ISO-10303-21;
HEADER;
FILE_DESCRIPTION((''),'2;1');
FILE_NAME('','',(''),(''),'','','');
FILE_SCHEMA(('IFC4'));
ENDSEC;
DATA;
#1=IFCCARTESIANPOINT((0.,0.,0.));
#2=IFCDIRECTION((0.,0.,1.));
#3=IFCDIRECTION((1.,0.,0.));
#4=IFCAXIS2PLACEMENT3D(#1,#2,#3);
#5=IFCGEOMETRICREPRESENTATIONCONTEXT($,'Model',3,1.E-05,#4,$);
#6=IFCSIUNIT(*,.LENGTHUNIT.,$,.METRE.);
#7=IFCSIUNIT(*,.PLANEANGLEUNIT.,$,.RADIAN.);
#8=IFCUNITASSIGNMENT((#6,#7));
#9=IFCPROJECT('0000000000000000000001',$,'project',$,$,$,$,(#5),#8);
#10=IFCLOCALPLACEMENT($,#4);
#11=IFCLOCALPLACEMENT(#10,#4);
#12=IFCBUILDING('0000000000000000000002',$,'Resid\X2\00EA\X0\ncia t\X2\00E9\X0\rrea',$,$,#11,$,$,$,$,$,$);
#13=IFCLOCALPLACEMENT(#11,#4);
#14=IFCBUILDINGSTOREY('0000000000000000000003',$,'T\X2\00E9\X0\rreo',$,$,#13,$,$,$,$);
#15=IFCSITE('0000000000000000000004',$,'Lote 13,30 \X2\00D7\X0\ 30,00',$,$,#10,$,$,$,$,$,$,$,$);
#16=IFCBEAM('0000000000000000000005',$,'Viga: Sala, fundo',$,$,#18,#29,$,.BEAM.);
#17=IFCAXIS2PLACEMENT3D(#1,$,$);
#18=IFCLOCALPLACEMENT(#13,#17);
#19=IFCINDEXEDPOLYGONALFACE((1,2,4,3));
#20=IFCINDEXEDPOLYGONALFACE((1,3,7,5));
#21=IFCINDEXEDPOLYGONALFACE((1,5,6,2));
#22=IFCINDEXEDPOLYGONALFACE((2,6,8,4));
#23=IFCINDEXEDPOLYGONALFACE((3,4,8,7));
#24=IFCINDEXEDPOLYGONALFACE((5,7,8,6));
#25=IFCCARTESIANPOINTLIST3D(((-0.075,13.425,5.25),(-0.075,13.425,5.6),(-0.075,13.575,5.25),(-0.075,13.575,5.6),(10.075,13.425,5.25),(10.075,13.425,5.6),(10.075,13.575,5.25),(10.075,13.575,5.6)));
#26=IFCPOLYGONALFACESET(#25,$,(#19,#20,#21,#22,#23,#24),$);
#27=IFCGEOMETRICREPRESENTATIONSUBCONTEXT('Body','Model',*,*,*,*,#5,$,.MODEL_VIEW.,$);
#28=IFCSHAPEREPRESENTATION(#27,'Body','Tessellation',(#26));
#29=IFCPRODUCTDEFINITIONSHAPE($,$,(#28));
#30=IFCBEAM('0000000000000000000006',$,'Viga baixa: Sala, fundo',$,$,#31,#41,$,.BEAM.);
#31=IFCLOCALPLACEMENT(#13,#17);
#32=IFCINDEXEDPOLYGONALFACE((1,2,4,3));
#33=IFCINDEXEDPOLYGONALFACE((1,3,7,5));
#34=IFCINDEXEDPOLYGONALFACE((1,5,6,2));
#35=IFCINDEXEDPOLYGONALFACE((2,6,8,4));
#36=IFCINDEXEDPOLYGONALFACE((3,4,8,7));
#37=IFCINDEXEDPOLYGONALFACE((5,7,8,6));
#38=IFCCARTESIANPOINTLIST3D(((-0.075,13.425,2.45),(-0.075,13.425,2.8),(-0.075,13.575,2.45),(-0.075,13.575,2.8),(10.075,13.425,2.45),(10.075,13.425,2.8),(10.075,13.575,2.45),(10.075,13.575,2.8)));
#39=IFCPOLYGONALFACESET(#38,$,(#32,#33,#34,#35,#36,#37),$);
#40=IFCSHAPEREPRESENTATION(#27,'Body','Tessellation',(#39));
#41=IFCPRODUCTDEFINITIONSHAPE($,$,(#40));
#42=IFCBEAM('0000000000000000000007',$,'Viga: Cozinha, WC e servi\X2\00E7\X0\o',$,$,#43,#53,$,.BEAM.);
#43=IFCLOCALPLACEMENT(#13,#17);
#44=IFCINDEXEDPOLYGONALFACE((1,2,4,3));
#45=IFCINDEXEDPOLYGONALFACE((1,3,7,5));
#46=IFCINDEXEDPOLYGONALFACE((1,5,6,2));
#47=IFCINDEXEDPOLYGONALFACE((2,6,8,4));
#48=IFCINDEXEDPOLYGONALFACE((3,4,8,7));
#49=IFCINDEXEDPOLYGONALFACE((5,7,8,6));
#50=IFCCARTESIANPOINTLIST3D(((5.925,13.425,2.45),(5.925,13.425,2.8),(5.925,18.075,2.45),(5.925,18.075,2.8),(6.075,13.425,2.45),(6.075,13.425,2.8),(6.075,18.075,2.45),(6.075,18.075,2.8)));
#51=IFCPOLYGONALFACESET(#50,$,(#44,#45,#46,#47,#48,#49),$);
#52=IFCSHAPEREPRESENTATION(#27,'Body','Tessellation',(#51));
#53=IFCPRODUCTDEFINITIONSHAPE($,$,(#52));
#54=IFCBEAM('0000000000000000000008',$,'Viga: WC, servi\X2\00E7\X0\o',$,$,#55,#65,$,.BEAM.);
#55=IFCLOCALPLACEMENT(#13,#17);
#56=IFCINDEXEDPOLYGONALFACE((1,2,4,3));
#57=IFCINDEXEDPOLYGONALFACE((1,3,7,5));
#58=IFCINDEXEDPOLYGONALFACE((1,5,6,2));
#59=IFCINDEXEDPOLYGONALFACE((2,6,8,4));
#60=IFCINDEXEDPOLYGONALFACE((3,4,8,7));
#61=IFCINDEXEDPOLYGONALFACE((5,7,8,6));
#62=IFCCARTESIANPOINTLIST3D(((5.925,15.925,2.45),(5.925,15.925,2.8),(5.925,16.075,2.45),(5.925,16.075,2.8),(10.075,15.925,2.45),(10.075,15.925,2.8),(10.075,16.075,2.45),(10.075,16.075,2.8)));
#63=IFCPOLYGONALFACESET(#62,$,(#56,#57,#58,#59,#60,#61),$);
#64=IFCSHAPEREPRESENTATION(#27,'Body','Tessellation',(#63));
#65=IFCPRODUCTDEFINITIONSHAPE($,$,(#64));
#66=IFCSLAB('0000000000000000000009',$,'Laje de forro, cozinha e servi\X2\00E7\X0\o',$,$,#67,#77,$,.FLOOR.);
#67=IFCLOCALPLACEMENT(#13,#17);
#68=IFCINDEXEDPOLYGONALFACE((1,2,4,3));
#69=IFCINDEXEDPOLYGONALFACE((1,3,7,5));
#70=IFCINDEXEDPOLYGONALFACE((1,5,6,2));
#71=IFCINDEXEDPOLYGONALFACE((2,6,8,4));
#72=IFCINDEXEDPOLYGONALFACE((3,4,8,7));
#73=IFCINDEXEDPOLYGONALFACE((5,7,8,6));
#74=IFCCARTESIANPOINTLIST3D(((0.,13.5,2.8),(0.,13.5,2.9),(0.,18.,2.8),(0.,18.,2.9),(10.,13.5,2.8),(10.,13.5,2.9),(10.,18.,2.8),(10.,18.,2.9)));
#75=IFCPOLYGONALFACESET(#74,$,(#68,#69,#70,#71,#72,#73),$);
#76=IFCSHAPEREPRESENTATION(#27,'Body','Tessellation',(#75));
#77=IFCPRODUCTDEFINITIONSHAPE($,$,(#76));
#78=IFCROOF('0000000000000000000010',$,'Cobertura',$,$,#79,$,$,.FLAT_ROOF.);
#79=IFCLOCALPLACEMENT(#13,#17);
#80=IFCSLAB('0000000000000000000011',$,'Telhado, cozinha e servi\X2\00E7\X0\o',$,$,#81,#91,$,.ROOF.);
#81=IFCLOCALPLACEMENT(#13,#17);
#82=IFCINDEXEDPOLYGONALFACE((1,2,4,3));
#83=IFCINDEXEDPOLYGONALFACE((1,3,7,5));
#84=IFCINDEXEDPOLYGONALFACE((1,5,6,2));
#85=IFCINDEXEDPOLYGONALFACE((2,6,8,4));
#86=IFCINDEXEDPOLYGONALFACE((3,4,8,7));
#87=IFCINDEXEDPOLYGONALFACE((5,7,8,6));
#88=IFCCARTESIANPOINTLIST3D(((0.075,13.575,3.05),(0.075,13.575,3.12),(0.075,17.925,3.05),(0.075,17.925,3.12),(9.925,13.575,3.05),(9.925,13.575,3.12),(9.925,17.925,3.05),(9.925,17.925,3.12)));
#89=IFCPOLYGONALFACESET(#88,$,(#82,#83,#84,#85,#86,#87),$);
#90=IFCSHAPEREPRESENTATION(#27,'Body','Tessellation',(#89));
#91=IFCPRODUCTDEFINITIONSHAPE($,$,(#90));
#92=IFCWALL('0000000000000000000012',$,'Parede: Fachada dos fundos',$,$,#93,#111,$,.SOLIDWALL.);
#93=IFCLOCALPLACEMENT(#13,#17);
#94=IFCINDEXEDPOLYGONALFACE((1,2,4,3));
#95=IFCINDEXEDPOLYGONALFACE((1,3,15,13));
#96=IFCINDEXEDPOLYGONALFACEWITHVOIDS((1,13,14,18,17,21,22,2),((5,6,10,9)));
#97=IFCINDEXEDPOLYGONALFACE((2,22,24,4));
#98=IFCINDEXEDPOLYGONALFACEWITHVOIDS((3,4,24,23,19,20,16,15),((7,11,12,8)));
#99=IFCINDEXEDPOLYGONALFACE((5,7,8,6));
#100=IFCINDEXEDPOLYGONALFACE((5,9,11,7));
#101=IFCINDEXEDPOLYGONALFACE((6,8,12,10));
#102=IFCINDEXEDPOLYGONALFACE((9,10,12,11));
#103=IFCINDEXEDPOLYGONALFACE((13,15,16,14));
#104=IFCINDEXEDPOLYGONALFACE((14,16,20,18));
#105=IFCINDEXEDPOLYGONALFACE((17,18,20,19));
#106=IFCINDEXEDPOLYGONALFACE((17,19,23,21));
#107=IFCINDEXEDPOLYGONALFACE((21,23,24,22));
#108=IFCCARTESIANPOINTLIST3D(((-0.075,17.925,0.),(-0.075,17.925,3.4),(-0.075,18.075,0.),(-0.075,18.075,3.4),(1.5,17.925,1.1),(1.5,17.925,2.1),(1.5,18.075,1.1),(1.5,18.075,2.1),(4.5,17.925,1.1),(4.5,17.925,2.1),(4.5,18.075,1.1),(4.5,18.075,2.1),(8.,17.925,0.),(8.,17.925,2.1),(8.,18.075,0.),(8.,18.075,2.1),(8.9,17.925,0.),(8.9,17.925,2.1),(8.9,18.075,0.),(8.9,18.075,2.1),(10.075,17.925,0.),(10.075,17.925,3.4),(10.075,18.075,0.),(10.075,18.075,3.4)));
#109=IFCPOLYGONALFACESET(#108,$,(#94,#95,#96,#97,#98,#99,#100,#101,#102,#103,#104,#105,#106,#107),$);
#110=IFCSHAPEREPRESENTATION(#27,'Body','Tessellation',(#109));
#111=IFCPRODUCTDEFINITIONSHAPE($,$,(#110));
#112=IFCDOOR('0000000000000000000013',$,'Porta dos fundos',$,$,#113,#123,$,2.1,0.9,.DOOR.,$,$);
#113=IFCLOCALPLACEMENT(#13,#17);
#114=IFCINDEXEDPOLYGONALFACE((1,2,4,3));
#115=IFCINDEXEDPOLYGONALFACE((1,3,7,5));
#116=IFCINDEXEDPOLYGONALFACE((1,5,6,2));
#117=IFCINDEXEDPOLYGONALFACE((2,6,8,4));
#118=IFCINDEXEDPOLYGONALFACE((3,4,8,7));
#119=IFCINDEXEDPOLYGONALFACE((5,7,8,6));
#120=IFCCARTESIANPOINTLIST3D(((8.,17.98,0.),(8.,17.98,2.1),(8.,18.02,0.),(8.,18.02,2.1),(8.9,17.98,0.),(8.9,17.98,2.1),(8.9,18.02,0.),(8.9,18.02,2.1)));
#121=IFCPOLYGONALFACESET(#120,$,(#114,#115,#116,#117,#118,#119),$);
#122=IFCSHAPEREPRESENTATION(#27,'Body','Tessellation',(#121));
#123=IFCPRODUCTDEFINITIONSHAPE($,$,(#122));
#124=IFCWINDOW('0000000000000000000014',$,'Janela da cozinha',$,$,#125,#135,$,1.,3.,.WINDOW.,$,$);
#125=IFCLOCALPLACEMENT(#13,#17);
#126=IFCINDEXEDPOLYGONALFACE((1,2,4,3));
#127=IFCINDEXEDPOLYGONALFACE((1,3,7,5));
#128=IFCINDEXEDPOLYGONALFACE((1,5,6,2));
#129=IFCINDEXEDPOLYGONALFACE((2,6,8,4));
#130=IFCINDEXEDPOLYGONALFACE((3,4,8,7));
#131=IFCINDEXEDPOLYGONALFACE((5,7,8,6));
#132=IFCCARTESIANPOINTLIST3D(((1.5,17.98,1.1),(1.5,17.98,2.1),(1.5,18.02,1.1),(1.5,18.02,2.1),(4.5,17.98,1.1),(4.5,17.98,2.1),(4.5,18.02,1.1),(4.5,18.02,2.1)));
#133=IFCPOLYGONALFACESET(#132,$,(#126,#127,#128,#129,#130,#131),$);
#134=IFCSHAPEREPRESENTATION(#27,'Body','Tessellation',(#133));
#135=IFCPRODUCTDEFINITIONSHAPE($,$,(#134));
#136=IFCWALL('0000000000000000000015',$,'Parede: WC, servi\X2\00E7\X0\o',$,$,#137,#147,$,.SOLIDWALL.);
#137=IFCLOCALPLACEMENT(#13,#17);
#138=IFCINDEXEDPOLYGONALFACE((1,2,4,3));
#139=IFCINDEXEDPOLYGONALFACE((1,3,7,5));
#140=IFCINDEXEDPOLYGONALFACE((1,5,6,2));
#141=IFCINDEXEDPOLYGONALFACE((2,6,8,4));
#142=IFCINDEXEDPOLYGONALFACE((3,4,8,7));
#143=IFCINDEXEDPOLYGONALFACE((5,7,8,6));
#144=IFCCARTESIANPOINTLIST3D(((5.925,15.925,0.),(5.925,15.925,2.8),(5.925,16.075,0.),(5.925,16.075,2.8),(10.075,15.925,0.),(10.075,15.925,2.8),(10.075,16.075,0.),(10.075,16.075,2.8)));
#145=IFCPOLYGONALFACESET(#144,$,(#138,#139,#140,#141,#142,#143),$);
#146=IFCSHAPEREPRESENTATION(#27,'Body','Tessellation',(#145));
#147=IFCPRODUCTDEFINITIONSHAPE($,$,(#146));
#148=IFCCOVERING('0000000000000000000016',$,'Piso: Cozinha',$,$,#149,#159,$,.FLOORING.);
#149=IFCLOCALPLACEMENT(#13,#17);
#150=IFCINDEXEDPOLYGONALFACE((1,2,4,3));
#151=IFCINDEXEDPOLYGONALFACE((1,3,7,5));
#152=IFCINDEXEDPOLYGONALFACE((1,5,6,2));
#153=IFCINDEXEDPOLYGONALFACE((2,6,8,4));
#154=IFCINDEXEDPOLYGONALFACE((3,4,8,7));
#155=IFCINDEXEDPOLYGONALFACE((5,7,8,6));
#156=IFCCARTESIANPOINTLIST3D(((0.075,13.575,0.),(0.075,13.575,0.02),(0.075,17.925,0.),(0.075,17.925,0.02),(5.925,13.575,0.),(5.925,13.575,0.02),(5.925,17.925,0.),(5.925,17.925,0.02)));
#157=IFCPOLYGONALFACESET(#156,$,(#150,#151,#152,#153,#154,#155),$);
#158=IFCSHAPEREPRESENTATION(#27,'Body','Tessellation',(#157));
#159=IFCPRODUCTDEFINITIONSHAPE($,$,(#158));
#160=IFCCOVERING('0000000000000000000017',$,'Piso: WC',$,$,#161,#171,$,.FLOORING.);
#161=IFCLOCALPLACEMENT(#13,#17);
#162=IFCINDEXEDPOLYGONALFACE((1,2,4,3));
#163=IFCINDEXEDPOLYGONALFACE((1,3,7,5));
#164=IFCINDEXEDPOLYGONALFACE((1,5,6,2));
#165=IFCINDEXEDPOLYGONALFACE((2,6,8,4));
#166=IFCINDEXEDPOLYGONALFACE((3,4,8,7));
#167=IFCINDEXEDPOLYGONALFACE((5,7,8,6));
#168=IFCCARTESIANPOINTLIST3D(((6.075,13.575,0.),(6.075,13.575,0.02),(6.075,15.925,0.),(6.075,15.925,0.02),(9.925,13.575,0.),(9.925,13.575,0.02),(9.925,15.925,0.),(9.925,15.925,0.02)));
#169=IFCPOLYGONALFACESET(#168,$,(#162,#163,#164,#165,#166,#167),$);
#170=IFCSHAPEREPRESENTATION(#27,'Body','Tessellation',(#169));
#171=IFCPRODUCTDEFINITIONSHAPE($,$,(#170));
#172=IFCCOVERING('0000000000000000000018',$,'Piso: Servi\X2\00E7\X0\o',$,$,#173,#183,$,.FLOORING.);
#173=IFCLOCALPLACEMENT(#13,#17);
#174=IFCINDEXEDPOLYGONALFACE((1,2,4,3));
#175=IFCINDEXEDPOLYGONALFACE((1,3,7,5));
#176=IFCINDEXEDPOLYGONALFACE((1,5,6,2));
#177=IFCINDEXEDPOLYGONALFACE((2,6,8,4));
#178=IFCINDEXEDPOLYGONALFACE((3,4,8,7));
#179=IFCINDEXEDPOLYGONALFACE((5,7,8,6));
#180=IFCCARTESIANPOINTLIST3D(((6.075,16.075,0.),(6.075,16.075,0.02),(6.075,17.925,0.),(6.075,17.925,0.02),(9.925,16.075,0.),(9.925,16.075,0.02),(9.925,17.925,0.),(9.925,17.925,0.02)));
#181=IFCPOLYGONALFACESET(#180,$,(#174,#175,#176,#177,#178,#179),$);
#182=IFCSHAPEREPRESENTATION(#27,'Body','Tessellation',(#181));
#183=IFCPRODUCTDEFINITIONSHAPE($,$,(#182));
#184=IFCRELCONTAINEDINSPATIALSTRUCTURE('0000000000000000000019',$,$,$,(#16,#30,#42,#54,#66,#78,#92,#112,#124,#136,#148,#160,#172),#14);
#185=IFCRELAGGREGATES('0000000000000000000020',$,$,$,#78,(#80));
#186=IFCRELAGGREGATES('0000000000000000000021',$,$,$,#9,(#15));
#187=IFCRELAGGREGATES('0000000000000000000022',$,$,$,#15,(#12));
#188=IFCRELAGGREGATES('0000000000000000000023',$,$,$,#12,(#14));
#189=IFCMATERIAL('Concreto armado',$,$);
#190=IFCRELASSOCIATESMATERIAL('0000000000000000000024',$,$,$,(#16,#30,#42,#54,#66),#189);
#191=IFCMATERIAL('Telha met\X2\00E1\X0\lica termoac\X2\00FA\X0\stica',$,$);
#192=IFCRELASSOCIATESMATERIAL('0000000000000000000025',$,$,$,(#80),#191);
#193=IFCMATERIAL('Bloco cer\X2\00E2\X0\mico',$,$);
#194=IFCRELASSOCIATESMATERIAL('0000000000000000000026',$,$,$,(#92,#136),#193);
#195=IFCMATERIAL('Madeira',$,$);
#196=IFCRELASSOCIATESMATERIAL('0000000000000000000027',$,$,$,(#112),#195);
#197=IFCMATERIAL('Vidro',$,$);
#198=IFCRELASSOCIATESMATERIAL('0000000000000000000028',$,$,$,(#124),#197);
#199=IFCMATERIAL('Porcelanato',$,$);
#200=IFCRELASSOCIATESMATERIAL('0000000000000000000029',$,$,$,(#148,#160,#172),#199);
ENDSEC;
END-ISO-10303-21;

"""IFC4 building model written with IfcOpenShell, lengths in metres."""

from ifc_helpers import new_model, si_unit, frame, origin_with_axes, place, context, subcontext, project, spatial, line, indexed_curve, outline, extrude, material, element, fill, aggregate, save


model = new_model("IFC4")

# Units and contexts
model_context = context("Model", 3, precision=1e-05, world=origin_with_axes())
body_context = subcontext(model_context, "Body", "Model", "MODEL_VIEW")
ifc_project = project(units=[si_unit("LENGTHUNIT", "METRE"), si_unit("PLANEANGLEUNIT", "RADIAN")], contexts=[model_context])

# Site, building, storey
site_placement = place(None, origin_with_axes())
site = spatial("IfcSite", under=ifc_project, at=site_placement, Name="Lote 13,30 × 30,00")
building_placement = place(site_placement, origin_with_axes())
building = spatial("IfcBuilding", under=site, at=building_placement, Name="Residência térrea")
storey_placement = place(building_placement, origin_with_axes())
storey = spatial("IfcBuildingStorey", under=building, at=storey_placement, Name="Térreo")

# Shared definitions
ifc_material_1 = material(Name="Concreto armado")

# Beams
beam_1_placement = place(storey_placement, frame((-0.075, 13.425, 5.25), z_axis=(0.0, 0.0, 1.0), x_axis=(1.0, 0.0, 0.0)))
element("IfcBeam", 1, at=beam_1_placement, inside=storey, material=ifc_material_1, Name="Viga: Sala, fundo", PredefinedType="BEAM", context=body_context, shape_type="SweptSolid", body=[
    extrude(outline(indexed_curve([(0.0, 0.0), (10.15, 0.0), (10.15, 0.15), (0.0, 0.15)], segments=[line(1, 2, 3, 4, 1)])), origin_with_axes(), (0.0, 0.0, 1.0), 0.35),
])
beam_2_placement = place(storey_placement, frame((-0.075, 13.425, 2.45), z_axis=(0.0, 0.0, 1.0), x_axis=(1.0, 0.0, 0.0)))
element("IfcBeam", 2, at=beam_2_placement, inside=storey, material=ifc_material_1, Name="Viga baixa: Sala, fundo", PredefinedType="BEAM", context=body_context, shape_type="SweptSolid", body=[
    extrude(outline(indexed_curve([(0.0, 0.0), (10.15, 0.0), (10.15, 0.15), (0.0, 0.15)], segments=[line(1, 2, 3, 4, 1)])), origin_with_axes(), (0.0, 0.0, 1.0), 0.35),
])
beam_3_placement = place(storey_placement, frame((5.925, 13.425, 2.45), z_axis=(0.0, 0.0, 1.0), x_axis=(1.0, 0.0, 0.0)))
element("IfcBeam", 3, at=beam_3_placement, inside=storey, material=ifc_material_1, Name="Viga: Cozinha, WC e serviço", PredefinedType="BEAM", context=body_context, shape_type="SweptSolid", body=[
    extrude(outline(indexed_curve([(0.0, 0.0), (0.15, 0.0), (0.15, 4.65), (0.0, 4.65)], segments=[line(1, 2, 3, 4, 1)])), origin_with_axes(), (0.0, 0.0, 1.0), 0.35),
])
beam_4_placement = place(storey_placement, frame((5.925, 15.925, 2.45), z_axis=(0.0, 0.0, 1.0), x_axis=(1.0, 0.0, 0.0)))
element("IfcBeam", 4, at=beam_4_placement, inside=storey, material=ifc_material_1, Name="Viga: WC, serviço", PredefinedType="BEAM", context=body_context, shape_type="SweptSolid", body=[
    extrude(outline(indexed_curve([(0.0, 0.0), (4.15, 0.0), (4.15, 0.15), (0.0, 0.15)], segments=[line(1, 2, 3, 4, 1)])), origin_with_axes(), (0.0, 0.0, 1.0), 0.35),
])

# Slab
slab_1_placement = place(storey_placement, frame((0.0, 13.5, 2.8), z_axis=(0.0, 0.0, 1.0), x_axis=(1.0, 0.0, 0.0)))
element("IfcSlab", 5, at=slab_1_placement, inside=storey, material=ifc_material_1, Name="Laje de forro, cozinha e serviço", PredefinedType="FLOOR", context=body_context, shape_type="SweptSolid", body=[
    extrude(outline(indexed_curve([(0.0, 0.0), (10.0, 0.0), (10.0, 4.5), (0.0, 4.5)], segments=[line(1, 2, 3, 4, 1)])), origin_with_axes(), (0.0, 0.0, 1.0), 0.1),
])

# Roof, slab
roof_placement = place(storey_placement, origin_with_axes())
roof = element("IfcRoof", 6, at=roof_placement, inside=storey, Name="Cobertura", PredefinedType="FLAT_ROOF")
ifc_material_2 = material(Name="Telha metálica termoacústica")
slab_2_placement = place(roof_placement, frame((0.075, 13.575, 3.05), z_axis=(0.0, 0.0, 1.0), x_axis=(1.0, 0.0, 0.0)))
slab_2 = element("IfcSlab", 7, at=slab_2_placement, material=ifc_material_2, Name="Telhado, cozinha e serviço", PredefinedType="ROOF", context=body_context, shape_type="SweptSolid", body=[
    extrude(outline(indexed_curve([(0.0, 0.0), (9.85, 0.0), (9.85, 4.35), (0.0, 4.35)], segments=[line(1, 2, 3, 4, 1)])), origin_with_axes(), (0.0, 0.0, 1.0), 0.07),
])
aggregate(roof, [slab_2])

# Wall, openings, door, window
ifc_material_3 = material(Name="Bloco cerâmico")
wall_1_placement = place(storey_placement, frame((-0.075, 17.925, 0.0), z_axis=(0.0, 0.0, 1.0), x_axis=(1.0, 0.0, 0.0)))
wall_1 = element("IfcWall", 8, at=wall_1_placement, inside=storey, material=ifc_material_3, Name="Parede: Fachada dos fundos", PredefinedType="SOLIDWALL", context=body_context, shape_type="SweptSolid", body=[
    extrude(outline(indexed_curve([(0.0, 0.0), (10.15, 0.0), (10.15, 0.15), (0.0, 0.15)], segments=[line(1, 2, 3, 4, 1)])), origin_with_axes(), (0.0, 0.0, 1.0), 3.4),
])
opening_1_placement = place(wall_1_placement, frame((8.075, -0.05, 0.0), z_axis=(0.0, 0.0, 1.0), x_axis=(1.0, 0.0, 0.0)))
opening_1 = element("IfcOpeningElement", 9, at=opening_1_placement, cuts=wall_1, material=ifc_material_1, PredefinedType="OPENING", context=body_context, shape_type="SweptSolid", body=[
    extrude(outline(indexed_curve([(0.0, 0.0), (0.9, 0.0), (0.9, 0.25), (0.0, 0.25)], segments=[line(1, 2, 3, 4, 1)])), origin_with_axes(), (0.0, 0.0, 1.0), 2.1),
])
opening_2_placement = place(wall_1_placement, frame((1.575, -0.05, 1.1), z_axis=(0.0, 0.0, 1.0), x_axis=(1.0, 0.0, 0.0)))
opening_2 = element("IfcOpeningElement", 10, at=opening_2_placement, cuts=wall_1, material=ifc_material_1, PredefinedType="OPENING", context=body_context, shape_type="SweptSolid", body=[
    extrude(outline(indexed_curve([(0.0, 0.0), (3.0, 0.0), (3.0, 0.25), (0.0, 0.25)], segments=[line(1, 2, 3, 4, 1)])), origin_with_axes(), (0.0, 0.0, 1.0), 1.0),
])
ifc_material_4 = material(Name="Madeira")
door_placement = place(storey_placement, frame((8.0, 17.98, 0.0), z_axis=(0.0, 0.0, 1.0), x_axis=(1.0, 0.0, 0.0)))
door = element("IfcDoor", 11, at=door_placement, inside=storey, material=ifc_material_4, Name="Porta dos fundos", OverallHeight=2.1, OverallWidth=0.9, PredefinedType="DOOR", context=body_context, shape_type="SweptSolid", body=[
    extrude(outline(indexed_curve([(0.0, 0.0), (0.9, 0.0), (0.9, 0.04), (0.0, 0.04)], segments=[line(1, 2, 3, 4, 1)])), origin_with_axes(), (0.0, 0.0, 1.0), 2.1),
])
fill(opening_1, door)
ifc_material_5 = material(Name="Vidro")
window_placement = place(storey_placement, frame((1.5, 17.98, 1.1), z_axis=(0.0, 0.0, 1.0), x_axis=(1.0, 0.0, 0.0)))
window = element("IfcWindow", 12, at=window_placement, inside=storey, material=ifc_material_5, Name="Janela da cozinha", OverallHeight=1.0, OverallWidth=3.0, PredefinedType="WINDOW", context=body_context, shape_type="SweptSolid", body=[
    extrude(outline(indexed_curve([(0.0, 0.0), (3.0, 0.0), (3.0, 0.04), (0.0, 0.04)], segments=[line(1, 2, 3, 4, 1)])), origin_with_axes(), (0.0, 0.0, 1.0), 1.0),
])
fill(opening_2, window)

# Wall
wall_2_placement = place(storey_placement, frame((5.925, 15.925, 0.0), z_axis=(0.0, 0.0, 1.0), x_axis=(1.0, 0.0, 0.0)))
element("IfcWall", 13, at=wall_2_placement, inside=storey, material=ifc_material_3, Name="Parede: WC, serviço", PredefinedType="SOLIDWALL", context=body_context, shape_type="SweptSolid", body=[
    extrude(outline(indexed_curve([(0.0, 0.0), (4.15, 0.0), (4.15, 0.15), (0.0, 0.15)], segments=[line(1, 2, 3, 4, 1)])), origin_with_axes(), (0.0, 0.0, 1.0), 2.8),
])

# Coverings
ifc_material_6 = material(Name="Porcelanato")
covering_1_placement = place(storey_placement, frame((0.075, 13.575, 0.0), z_axis=(0.0, 0.0, 1.0), x_axis=(1.0, 0.0, 0.0)))
element("IfcCovering", 14, at=covering_1_placement, inside=storey, material=ifc_material_6, Name="Piso: Cozinha", PredefinedType="FLOORING", context=body_context, shape_type="SweptSolid", body=[
    extrude(outline(indexed_curve([(0.0, 0.0), (5.85, 0.0), (5.85, 4.35), (0.0, 4.35)], segments=[line(1, 2, 3, 4, 1)])), origin_with_axes(), (0.0, 0.0, 1.0), 0.02),
])
covering_2_placement = place(storey_placement, frame((6.075, 13.575, 0.0), z_axis=(0.0, 0.0, 1.0), x_axis=(1.0, 0.0, 0.0)))
element("IfcCovering", 15, at=covering_2_placement, inside=storey, material=ifc_material_6, Name="Piso: WC", PredefinedType="FLOORING", context=body_context, shape_type="SweptSolid", body=[
    extrude(outline(indexed_curve([(0.0, 0.0), (3.85, 0.0), (3.85, 2.35), (0.0, 2.35)], segments=[line(1, 2, 3, 4, 1)])), origin_with_axes(), (0.0, 0.0, 1.0), 0.02),
])
covering_3_placement = place(storey_placement, frame((6.075, 16.075, 0.0), z_axis=(0.0, 0.0, 1.0), x_axis=(1.0, 0.0, 0.0)))
element("IfcCovering", 16, at=covering_3_placement, inside=storey, material=ifc_material_6, Name="Piso: Serviço", PredefinedType="FLOORING", context=body_context, shape_type="SweptSolid", body=[
    extrude(outline(indexed_curve([(0.0, 0.0), (3.85, 0.0), (3.85, 1.85), (0.0, 1.85)], segments=[line(1, 2, 3, 4, 1)])), origin_with_axes(), (0.0, 0.0, 1.0), 0.02),
])

save(model, "model.ifc")
